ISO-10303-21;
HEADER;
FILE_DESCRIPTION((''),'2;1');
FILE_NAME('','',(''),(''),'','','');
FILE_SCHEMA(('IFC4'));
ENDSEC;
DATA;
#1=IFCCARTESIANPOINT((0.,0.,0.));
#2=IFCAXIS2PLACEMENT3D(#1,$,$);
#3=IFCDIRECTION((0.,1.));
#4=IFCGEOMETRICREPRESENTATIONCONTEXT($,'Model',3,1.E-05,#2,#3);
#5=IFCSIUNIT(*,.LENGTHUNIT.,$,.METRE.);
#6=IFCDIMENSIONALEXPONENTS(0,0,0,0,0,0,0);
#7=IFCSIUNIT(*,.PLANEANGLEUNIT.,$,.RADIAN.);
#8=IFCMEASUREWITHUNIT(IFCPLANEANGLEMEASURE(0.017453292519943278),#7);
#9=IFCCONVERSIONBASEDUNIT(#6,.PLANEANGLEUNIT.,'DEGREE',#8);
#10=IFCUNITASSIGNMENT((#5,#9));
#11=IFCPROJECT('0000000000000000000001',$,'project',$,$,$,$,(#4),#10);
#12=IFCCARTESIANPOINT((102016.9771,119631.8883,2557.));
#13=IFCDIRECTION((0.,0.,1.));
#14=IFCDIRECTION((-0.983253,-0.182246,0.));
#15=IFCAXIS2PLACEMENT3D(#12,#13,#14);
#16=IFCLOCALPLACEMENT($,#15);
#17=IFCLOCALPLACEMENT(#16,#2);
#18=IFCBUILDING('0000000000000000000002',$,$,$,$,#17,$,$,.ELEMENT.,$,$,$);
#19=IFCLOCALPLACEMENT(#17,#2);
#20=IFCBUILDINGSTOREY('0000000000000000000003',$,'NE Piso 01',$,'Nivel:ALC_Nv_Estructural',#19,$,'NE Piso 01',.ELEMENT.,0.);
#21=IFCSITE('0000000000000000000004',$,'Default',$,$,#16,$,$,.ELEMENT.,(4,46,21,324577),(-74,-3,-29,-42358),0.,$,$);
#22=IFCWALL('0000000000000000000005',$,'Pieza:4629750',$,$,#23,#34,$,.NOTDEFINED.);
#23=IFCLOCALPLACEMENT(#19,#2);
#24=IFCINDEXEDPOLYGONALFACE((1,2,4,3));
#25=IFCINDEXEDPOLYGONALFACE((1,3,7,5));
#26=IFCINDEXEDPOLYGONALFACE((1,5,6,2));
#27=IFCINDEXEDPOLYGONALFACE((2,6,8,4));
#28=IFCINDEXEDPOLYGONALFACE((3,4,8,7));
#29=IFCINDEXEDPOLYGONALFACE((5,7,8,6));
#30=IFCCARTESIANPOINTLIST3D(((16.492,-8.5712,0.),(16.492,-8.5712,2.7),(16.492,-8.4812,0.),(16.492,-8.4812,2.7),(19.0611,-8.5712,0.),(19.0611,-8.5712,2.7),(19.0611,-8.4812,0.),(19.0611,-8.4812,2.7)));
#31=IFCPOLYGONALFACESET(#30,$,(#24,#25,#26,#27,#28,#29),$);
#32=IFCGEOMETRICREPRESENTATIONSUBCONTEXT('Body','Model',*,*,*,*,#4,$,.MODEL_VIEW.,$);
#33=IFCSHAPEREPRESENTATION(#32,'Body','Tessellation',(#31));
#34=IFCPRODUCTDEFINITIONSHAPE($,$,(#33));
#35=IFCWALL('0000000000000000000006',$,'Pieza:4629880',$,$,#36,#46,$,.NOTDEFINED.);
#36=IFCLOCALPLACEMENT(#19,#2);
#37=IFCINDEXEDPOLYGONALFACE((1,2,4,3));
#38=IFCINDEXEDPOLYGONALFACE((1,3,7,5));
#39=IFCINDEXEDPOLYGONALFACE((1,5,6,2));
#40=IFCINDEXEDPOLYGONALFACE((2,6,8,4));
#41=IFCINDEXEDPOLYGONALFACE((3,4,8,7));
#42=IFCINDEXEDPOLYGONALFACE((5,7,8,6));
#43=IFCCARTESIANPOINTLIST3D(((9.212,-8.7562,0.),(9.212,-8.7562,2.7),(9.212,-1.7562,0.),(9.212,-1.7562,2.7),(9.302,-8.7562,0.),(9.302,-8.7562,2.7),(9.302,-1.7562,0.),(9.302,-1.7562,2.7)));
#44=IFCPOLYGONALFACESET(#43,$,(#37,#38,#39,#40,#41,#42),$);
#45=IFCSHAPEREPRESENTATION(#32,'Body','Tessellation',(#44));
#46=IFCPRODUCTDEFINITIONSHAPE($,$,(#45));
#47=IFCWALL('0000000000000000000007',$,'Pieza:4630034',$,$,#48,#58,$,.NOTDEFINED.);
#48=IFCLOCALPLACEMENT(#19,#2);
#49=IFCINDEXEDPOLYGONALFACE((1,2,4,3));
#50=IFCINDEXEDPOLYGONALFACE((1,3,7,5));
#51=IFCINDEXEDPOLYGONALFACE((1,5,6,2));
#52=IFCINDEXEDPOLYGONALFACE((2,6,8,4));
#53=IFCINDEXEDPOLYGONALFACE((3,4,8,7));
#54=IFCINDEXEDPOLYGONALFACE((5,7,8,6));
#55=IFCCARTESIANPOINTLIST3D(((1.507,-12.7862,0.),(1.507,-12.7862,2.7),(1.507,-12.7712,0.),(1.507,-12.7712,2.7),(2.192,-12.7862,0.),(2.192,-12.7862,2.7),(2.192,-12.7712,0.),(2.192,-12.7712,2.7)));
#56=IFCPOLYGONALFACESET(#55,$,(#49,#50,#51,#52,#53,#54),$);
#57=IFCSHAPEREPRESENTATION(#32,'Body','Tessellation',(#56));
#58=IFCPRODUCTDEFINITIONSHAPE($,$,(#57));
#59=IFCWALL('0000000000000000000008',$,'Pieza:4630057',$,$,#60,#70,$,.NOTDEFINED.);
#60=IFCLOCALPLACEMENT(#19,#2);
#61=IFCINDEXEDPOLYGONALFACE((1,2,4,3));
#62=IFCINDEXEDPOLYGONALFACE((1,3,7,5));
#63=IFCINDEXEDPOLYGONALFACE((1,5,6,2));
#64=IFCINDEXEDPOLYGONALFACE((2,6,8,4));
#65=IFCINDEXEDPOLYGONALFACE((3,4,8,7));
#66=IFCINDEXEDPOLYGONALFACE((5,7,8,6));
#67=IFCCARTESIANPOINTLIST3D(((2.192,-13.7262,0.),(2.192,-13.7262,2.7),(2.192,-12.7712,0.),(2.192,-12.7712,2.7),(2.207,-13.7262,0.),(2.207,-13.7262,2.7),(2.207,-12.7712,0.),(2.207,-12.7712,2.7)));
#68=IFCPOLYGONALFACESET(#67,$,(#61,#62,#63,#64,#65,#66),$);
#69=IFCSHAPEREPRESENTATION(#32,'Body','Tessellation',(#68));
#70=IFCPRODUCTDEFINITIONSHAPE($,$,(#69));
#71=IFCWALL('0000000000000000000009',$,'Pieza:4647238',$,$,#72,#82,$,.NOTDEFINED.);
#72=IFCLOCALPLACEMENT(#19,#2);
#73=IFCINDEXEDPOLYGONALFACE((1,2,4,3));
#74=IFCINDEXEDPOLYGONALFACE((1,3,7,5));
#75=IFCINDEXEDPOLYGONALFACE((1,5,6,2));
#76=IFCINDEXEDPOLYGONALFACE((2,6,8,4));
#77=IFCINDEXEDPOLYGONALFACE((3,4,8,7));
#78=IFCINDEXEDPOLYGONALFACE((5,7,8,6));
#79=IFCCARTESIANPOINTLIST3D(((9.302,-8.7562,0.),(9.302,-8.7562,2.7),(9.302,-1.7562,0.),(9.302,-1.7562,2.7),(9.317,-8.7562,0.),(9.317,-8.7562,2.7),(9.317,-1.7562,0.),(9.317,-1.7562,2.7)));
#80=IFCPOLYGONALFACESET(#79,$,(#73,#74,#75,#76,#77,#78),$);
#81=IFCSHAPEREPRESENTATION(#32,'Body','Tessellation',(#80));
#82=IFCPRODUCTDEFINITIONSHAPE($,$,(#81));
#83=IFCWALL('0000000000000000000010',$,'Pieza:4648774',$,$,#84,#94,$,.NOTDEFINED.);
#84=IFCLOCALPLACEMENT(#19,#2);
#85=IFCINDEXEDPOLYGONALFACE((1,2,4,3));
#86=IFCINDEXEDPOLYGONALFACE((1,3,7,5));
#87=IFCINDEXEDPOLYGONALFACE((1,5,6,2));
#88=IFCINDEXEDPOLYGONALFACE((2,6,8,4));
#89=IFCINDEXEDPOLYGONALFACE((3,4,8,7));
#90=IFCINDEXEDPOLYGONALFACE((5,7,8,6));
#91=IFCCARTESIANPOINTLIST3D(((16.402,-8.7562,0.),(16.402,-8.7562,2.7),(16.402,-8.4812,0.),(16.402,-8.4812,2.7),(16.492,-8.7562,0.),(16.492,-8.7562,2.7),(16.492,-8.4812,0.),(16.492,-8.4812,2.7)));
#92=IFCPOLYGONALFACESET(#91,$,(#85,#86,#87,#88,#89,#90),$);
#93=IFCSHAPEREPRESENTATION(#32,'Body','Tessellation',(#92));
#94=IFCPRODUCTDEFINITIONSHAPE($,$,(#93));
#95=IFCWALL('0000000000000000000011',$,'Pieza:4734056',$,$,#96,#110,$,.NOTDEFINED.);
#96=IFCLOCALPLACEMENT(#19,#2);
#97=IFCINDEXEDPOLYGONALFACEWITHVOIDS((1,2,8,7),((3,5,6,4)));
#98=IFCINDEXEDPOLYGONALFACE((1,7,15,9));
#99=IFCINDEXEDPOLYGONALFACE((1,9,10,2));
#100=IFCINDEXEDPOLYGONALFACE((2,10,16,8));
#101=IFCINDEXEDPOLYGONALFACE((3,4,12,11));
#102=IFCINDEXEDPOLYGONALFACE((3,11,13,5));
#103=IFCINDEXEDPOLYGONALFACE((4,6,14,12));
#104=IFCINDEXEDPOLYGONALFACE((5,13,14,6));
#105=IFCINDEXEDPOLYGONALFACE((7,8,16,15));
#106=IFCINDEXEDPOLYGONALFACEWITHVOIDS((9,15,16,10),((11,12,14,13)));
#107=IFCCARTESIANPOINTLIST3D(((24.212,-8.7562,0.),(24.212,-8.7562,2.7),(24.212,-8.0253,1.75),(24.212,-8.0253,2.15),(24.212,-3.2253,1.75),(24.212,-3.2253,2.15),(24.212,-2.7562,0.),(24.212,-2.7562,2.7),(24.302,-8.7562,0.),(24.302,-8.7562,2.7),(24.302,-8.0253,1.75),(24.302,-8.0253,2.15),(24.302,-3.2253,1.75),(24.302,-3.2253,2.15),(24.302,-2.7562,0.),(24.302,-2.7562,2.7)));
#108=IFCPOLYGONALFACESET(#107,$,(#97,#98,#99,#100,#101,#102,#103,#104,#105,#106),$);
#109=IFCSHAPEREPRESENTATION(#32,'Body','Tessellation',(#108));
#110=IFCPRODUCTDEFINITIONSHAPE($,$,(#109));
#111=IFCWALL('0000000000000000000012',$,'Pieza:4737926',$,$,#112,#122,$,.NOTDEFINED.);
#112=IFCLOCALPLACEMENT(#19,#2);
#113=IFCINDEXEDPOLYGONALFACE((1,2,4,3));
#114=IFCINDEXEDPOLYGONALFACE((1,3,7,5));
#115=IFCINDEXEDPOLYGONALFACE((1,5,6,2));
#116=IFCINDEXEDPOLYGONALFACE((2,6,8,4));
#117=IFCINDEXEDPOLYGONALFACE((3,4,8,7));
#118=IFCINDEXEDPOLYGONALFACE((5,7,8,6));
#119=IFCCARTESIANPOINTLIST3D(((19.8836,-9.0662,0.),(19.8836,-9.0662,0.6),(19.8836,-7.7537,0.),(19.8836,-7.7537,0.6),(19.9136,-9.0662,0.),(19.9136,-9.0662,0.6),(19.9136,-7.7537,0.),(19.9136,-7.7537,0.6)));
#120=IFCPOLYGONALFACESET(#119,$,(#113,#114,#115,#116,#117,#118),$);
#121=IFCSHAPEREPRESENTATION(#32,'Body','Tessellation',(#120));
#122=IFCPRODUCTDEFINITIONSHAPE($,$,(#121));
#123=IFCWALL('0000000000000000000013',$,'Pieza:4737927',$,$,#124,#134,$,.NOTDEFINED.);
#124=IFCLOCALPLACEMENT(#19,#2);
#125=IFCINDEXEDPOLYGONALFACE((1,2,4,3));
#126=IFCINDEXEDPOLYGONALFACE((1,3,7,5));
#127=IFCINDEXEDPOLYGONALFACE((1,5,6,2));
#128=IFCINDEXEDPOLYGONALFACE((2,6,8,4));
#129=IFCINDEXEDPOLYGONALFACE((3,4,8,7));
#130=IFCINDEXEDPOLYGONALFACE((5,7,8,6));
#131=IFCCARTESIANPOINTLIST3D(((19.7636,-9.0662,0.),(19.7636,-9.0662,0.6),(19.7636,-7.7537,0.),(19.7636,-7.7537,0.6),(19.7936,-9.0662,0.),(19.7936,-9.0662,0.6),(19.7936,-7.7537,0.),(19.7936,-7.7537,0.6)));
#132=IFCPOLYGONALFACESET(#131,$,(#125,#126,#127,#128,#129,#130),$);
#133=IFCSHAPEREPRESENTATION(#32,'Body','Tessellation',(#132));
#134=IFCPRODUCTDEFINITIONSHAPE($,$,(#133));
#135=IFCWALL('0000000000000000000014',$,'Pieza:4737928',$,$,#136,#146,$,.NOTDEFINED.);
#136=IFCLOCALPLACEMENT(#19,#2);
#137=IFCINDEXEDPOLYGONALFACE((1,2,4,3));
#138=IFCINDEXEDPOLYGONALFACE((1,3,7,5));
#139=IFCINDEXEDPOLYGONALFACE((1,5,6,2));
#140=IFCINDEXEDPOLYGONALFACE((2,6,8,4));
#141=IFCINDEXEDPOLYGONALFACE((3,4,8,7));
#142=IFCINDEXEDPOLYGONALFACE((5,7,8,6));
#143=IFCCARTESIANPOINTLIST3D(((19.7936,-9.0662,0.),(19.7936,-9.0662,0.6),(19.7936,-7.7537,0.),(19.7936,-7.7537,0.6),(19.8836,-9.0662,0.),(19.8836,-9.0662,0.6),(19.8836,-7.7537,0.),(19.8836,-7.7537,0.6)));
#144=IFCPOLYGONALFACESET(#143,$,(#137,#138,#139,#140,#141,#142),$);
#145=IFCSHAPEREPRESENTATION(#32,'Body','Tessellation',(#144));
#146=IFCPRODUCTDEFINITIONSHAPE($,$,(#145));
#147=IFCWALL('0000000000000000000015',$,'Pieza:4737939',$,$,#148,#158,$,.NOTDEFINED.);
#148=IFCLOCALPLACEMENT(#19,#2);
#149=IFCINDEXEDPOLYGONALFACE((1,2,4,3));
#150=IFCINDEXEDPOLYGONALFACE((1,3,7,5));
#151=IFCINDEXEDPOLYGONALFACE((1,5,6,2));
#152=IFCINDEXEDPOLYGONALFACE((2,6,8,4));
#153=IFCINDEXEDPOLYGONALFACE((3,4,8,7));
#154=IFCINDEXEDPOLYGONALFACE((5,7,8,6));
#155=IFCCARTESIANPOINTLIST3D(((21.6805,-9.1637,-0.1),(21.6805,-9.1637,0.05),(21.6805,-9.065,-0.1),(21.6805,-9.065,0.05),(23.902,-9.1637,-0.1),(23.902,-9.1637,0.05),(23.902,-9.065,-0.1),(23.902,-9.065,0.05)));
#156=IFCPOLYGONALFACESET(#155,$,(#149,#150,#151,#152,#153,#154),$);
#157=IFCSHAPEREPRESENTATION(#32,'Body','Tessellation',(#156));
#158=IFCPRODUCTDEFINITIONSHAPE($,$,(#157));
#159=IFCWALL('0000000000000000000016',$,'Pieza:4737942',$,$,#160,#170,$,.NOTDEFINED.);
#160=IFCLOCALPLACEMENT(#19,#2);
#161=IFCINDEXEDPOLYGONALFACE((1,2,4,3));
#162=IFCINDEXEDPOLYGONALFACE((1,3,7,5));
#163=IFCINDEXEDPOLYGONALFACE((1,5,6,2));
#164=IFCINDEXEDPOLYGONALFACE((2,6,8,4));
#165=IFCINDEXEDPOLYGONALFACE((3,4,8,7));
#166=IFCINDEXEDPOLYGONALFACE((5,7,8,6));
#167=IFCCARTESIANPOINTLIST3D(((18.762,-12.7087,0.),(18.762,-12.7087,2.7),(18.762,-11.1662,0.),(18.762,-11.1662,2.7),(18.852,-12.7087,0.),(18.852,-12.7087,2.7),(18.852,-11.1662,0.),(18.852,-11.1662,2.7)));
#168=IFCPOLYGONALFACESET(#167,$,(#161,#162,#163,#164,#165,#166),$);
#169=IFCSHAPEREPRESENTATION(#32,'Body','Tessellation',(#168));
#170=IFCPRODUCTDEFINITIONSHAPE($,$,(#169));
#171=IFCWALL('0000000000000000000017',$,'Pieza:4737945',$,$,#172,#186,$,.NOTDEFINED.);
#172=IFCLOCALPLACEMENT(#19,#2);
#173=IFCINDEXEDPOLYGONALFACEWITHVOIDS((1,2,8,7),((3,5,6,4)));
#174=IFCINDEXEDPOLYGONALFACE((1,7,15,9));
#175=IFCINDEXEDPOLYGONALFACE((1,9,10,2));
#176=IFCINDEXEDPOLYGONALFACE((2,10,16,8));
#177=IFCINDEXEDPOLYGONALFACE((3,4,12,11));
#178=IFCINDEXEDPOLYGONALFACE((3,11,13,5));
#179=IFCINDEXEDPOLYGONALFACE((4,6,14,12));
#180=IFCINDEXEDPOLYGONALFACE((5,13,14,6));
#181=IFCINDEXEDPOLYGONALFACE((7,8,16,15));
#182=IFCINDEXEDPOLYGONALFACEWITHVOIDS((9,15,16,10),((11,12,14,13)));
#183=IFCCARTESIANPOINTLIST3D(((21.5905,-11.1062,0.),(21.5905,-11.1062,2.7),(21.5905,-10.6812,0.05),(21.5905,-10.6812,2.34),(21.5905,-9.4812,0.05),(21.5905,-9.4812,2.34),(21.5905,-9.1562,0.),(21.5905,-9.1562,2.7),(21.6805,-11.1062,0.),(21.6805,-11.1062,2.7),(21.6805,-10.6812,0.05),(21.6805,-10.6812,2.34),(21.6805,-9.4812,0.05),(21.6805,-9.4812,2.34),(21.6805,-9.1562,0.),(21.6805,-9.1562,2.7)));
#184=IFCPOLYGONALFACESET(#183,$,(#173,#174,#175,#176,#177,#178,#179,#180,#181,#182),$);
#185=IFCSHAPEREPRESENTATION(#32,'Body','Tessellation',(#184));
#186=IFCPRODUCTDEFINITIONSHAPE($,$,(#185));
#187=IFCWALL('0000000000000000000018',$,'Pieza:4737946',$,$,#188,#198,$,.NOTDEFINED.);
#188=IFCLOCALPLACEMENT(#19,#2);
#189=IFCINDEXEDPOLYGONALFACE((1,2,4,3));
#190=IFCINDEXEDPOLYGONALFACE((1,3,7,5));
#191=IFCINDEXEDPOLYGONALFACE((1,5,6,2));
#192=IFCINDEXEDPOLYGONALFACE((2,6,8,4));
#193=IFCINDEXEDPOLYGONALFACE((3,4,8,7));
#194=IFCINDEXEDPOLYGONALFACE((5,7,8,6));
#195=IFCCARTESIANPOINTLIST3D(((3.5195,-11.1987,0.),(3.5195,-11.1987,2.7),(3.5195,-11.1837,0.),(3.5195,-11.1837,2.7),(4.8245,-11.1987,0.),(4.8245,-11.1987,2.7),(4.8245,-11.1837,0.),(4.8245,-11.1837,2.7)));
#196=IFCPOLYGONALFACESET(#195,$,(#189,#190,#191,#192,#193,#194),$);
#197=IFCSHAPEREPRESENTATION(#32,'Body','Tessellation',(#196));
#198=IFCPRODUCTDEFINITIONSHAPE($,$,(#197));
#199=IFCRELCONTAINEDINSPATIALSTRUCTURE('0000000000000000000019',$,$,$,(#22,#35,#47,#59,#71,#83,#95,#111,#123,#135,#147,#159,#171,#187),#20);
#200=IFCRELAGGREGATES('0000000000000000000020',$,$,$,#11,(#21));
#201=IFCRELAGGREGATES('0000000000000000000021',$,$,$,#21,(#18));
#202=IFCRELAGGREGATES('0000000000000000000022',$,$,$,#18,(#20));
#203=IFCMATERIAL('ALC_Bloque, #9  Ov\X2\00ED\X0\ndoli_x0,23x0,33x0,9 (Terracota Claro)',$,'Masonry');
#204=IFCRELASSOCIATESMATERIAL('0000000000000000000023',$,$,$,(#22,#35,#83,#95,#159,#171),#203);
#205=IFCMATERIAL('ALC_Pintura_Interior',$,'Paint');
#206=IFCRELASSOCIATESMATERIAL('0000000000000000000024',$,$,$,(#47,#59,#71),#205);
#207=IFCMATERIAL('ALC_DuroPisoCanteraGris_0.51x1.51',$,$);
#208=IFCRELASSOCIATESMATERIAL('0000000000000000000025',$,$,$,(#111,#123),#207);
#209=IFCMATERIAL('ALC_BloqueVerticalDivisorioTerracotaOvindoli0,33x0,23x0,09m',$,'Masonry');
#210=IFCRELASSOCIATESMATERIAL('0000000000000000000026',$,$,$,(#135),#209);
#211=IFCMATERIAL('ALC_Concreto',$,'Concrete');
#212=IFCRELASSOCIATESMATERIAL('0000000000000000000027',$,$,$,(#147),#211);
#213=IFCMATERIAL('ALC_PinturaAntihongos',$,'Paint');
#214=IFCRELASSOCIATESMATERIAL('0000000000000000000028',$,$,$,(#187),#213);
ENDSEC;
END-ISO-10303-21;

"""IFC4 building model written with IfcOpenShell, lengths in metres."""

from ifc_helpers import new_model, entity, si_unit, converted_unit, direction, frame, frame_2d, origin, origin_2d_with_axis, place, context, subcontext, project, spatial, rectangle, extrude, boolean, material, element, save


model = new_model("IFC4")

# Units and contexts
model_context = context("Model", 3, precision=1e-05, world=origin(), true_north=direction((0.0, 1.0)))
body_context = subcontext(model_context, "Body", "Model", "MODEL_VIEW")
ifc_project = project(units=[si_unit("LENGTHUNIT", "METRE"), converted_unit("PLANEANGLEUNIT", "DEGREE", entity("IfcPlaneAngleMeasure", 0.017453292519943278), si_unit("PLANEANGLEUNIT", "RADIAN"), dimensions=[0, 0, 0, 0, 0, 0, 0])], contexts=[model_context])

# Site, building, storey
site_placement = place(None, frame((102016.9771, 119631.8883, 2557.0), z_axis=(0.0, 0.0, 1.0), x_axis=(-0.983253, -0.182246, 0.0)))
site = spatial("IfcSite", under=ifc_project, at=site_placement, Name="Default", CompositionType="ELEMENT", RefLatitude=(4, 46, 21, 324577), RefLongitude=(-74, -3, -29, -42358), RefElevation=0.0)
building_placement = place(site_placement, origin())
building = spatial("IfcBuilding", under=site, at=building_placement, CompositionType="ELEMENT")
storey_placement = place(building_placement, origin())
storey = spatial("IfcBuildingStorey", under=building, at=storey_placement, Name="NE Piso 01", ObjectType="Nivel:ALC_Nv_Estructural", LongName="NE Piso 01", CompositionType="ELEMENT", Elevation=0.0)

# Walls
ifc_material_1 = material(Name="ALC_Bloque, #9  Ovíndoli_x0,23x0,33x0,9 (Terracota Claro)", Category="Masonry")
wall_1_placement = place(storey_placement, origin())
element("IfcWall", 1, at=wall_1_placement, inside=storey, material=ifc_material_1, Name="Pieza:4629750", PredefinedType="NOTDEFINED", context=body_context, shape_type="SweptSolid", body=[
    extrude(rectangle(XDim=0.09, YDim=2.5691, at=frame_2d((0.0, 0.0), x_axis=(1.0, 0.0))), frame((17.7766, -8.5262, 0.0), z_axis=(0.0, 0.0, 1.0), x_axis=(0.0, -1.0, 0.0)), (0.0, 0.0, 1.0), 2.7),
])
wall_2_placement = place(storey_placement, origin())
element("IfcWall", 2, at=wall_2_placement, inside=storey, material=ifc_material_1, Name="Pieza:4629880", PredefinedType="NOTDEFINED", context=body_context, shape_type="SweptSolid", body=[
    extrude(rectangle(XDim=7.0, YDim=0.09, at=frame_2d((0.0, 0.0), x_axis=(1.0, 0.0))), frame((9.257, -5.2562, 0.0), z_axis=(0.0, 0.0, 1.0), x_axis=(0.0, -1.0, 0.0)), (0.0, 0.0, 1.0), 2.7),
])
ifc_material_2 = material(Name="ALC_Pintura_Interior", Category="Paint")
wall_3_placement = place(storey_placement, origin())
element("IfcWall", 3, at=wall_3_placement, inside=storey, material=ifc_material_2, Name="Pieza:4630034", PredefinedType="NOTDEFINED", context=body_context, shape_type="SweptSolid", body=[
    extrude(rectangle(XDim=0.015, YDim=0.685, at=frame_2d((0.0, 0.0), x_axis=(1.0, 0.0))), frame((1.8495, -12.7787, 0.0), z_axis=(0.0, 0.0, 1.0), x_axis=(0.0, -1.0, 0.0)), (0.0, 0.0, 1.0), 2.7),
])
wall_4_placement = place(storey_placement, origin())
element("IfcWall", 4, at=wall_4_placement, inside=storey, material=ifc_material_2, Name="Pieza:4630057", PredefinedType="NOTDEFINED", context=body_context, shape_type="SweptSolid", body=[
    extrude(rectangle(XDim=0.955, YDim=0.015, at=frame_2d((0.0, 0.0), x_axis=(1.0, 0.0))), frame((2.1995, -13.2487, 0.0), z_axis=(0.0, 0.0, 1.0), x_axis=(0.0, -1.0, 0.0)), (0.0, 0.0, 1.0), 2.7),
])
wall_5_placement = place(storey_placement, origin())
element("IfcWall", 5, at=wall_5_placement, inside=storey, material=ifc_material_2, Name="Pieza:4647238", PredefinedType="NOTDEFINED", context=body_context, shape_type="SweptSolid", body=[
    extrude(rectangle(XDim=7.0, YDim=0.015, at=frame_2d((0.0, 0.0), x_axis=(1.0, 0.0))), frame((9.3095, -5.2562, 0.0), z_axis=(0.0, 0.0, 1.0), x_axis=(0.0, -1.0, 0.0)), (0.0, 0.0, 1.0), 2.7),
])
wall_6_placement = place(storey_placement, origin())
element("IfcWall", 6, at=wall_6_placement, inside=storey, material=ifc_material_1, Name="Pieza:4648774", PredefinedType="NOTDEFINED", context=body_context, shape_type="SweptSolid", body=[
    extrude(rectangle(XDim=0.275, YDim=0.09, at=frame_2d((0.0, 0.0), x_axis=(1.0, 0.0))), frame((16.447, -8.6187, 0.0), z_axis=(0.0, 0.0, 1.0), x_axis=(0.0, -1.0, 0.0)), (0.0, 0.0, 1.0), 2.7),
])
wall_7_placement = place(storey_placement, origin())
element("IfcWall", 7, at=wall_7_placement, inside=storey, material=ifc_material_1, Name="Pieza:4734056", PredefinedType="NOTDEFINED", context=body_context, shape_type="SweptSolid", body=[
    boolean("DIFFERENCE", extrude(rectangle(XDim=0.09, YDim=6.0, at=origin_2d_with_axis()), frame((24.257, -5.7562, 0.0)), (0.0, 0.0, 1.0), 2.7), extrude(rectangle(XDim=0.4, YDim=4.8, at=frame_2d((0.0, 0.0), x_axis=(0.0, 1.0))), frame((24.302, -5.6253, 1.95), z_axis=(-1.0, 0.0, 0.0), x_axis=(0.0, 1.0, 0.0)), (0.0, 0.0, 1.0), 0.09)),
])
ifc_material_3 = material(Name="ALC_DuroPisoCanteraGris_0.51x1.51")
wall_8_placement = place(storey_placement, origin())
element("IfcWall", 8, at=wall_8_placement, inside=storey, material=ifc_material_3, Name="Pieza:4737926", PredefinedType="NOTDEFINED", context=body_context, shape_type="SweptSolid", body=[
    extrude(rectangle(XDim=1.3125, YDim=0.03, at=frame_2d((0.0, 0.0), x_axis=(1.0, 0.0))), frame((19.8986, -8.4099, 0.0), z_axis=(0.0, 0.0, 1.0), x_axis=(0.0, -1.0, 0.0)), (0.0, 0.0, 1.0), 0.6),
])
wall_9_placement = place(storey_placement, origin())
element("IfcWall", 9, at=wall_9_placement, inside=storey, material=ifc_material_3, Name="Pieza:4737927", PredefinedType="NOTDEFINED", context=body_context, shape_type="SweptSolid", body=[
    extrude(rectangle(XDim=1.3125, YDim=0.03, at=frame_2d((0.0, 0.0), x_axis=(1.0, 0.0))), frame((19.7786, -8.4099, 0.0), z_axis=(0.0, 0.0, 1.0), x_axis=(0.0, -1.0, 0.0)), (0.0, 0.0, 1.0), 0.6),
])
ifc_material_4 = material(Name="ALC_BloqueVerticalDivisorioTerracotaOvindoli0,33x0,23x0,09m", Category="Masonry")
wall_10_placement = place(storey_placement, origin())
element("IfcWall", 10, at=wall_10_placement, inside=storey, material=ifc_material_4, Name="Pieza:4737928", PredefinedType="NOTDEFINED", context=body_context, shape_type="SweptSolid", body=[
    extrude(rectangle(XDim=1.3125, YDim=0.09, at=frame_2d((0.0, 0.0), x_axis=(1.0, 0.0))), frame((19.8386, -8.4099, 0.0), z_axis=(0.0, 0.0, 1.0), x_axis=(0.0, -1.0, 0.0)), (0.0, 0.0, 1.0), 0.6),
])
ifc_material_5 = material(Name="ALC_Concreto", Category="Concrete")
wall_11_placement = place(storey_placement, frame((0.0, 0.0, -0.1)))
element("IfcWall", 11, at=wall_11_placement, inside=storey, material=ifc_material_5, Name="Pieza:4737939", PredefinedType="NOTDEFINED", context=body_context, shape_type="SweptSolid", body=[
    extrude(rectangle(XDim=0.0987, YDim=2.2215, at=origin_2d_with_axis()), frame((22.7913, -9.1143, 0.0), z_axis=(0.0, 0.0, 1.0), x_axis=(0.0, -1.0, 0.0)), (0.0, 0.0, 1.0), 0.15),
])
wall_12_placement = place(storey_placement, origin())
element("IfcWall", 12, at=wall_12_placement, inside=storey, material=ifc_material_1, Name="Pieza:4737942", PredefinedType="NOTDEFINED", context=body_context, shape_type="SweptSolid", body=[
    extrude(rectangle(XDim=1.5425, YDim=0.09, at=frame_2d((0.0, 0.0), x_axis=(1.0, 0.0))), frame((18.807, -11.9374, 0.0), z_axis=(0.0, 0.0, 1.0), x_axis=(0.0, -1.0, 0.0)), (0.0, 0.0, 1.0), 2.7),
])
wall_13_placement = place(storey_placement, origin())
element("IfcWall", 13, at=wall_13_placement, inside=storey, material=ifc_material_1, Name="Pieza:4737945", PredefinedType="NOTDEFINED", context=body_context, shape_type="SweptSolid", body=[
    boolean("DIFFERENCE", extrude(rectangle(XDim=0.09, YDim=1.95, at=frame_2d((0.0, 0.0), x_axis=(1.0, 0.0))), frame((21.6355, -10.1312, 0.0)), (0.0, 0.0, 1.0), 2.7), extrude(rectangle(XDim=2.29, YDim=1.2, at=frame_2d((0.0, 0.0), x_axis=(0.0, 1.0))), frame((21.6805, -10.0812, 1.195), z_axis=(-1.0, 0.0, 0.0), x_axis=(0.0, 1.0, 0.0)), (0.0, 0.0, 1.0), 0.09)),
])
ifc_material_6 = material(Name="ALC_PinturaAntihongos", Category="Paint")
wall_14_placement = place(storey_placement, origin())
element("IfcWall", 14, at=wall_14_placement, inside=storey, material=ifc_material_6, Name="Pieza:4737946", PredefinedType="NOTDEFINED", context=body_context, shape_type="SweptSolid", body=[
    extrude(rectangle(XDim=0.015, YDim=1.305, at=frame_2d((0.0, 0.0), x_axis=(1.0, 0.0))), frame((4.172, -11.1912, 0.0), z_axis=(0.0, 0.0, 1.0), x_axis=(0.0, -1.0, 0.0)), (0.0, 0.0, 1.0), 2.7),
])

save(model, "model.ifc")
